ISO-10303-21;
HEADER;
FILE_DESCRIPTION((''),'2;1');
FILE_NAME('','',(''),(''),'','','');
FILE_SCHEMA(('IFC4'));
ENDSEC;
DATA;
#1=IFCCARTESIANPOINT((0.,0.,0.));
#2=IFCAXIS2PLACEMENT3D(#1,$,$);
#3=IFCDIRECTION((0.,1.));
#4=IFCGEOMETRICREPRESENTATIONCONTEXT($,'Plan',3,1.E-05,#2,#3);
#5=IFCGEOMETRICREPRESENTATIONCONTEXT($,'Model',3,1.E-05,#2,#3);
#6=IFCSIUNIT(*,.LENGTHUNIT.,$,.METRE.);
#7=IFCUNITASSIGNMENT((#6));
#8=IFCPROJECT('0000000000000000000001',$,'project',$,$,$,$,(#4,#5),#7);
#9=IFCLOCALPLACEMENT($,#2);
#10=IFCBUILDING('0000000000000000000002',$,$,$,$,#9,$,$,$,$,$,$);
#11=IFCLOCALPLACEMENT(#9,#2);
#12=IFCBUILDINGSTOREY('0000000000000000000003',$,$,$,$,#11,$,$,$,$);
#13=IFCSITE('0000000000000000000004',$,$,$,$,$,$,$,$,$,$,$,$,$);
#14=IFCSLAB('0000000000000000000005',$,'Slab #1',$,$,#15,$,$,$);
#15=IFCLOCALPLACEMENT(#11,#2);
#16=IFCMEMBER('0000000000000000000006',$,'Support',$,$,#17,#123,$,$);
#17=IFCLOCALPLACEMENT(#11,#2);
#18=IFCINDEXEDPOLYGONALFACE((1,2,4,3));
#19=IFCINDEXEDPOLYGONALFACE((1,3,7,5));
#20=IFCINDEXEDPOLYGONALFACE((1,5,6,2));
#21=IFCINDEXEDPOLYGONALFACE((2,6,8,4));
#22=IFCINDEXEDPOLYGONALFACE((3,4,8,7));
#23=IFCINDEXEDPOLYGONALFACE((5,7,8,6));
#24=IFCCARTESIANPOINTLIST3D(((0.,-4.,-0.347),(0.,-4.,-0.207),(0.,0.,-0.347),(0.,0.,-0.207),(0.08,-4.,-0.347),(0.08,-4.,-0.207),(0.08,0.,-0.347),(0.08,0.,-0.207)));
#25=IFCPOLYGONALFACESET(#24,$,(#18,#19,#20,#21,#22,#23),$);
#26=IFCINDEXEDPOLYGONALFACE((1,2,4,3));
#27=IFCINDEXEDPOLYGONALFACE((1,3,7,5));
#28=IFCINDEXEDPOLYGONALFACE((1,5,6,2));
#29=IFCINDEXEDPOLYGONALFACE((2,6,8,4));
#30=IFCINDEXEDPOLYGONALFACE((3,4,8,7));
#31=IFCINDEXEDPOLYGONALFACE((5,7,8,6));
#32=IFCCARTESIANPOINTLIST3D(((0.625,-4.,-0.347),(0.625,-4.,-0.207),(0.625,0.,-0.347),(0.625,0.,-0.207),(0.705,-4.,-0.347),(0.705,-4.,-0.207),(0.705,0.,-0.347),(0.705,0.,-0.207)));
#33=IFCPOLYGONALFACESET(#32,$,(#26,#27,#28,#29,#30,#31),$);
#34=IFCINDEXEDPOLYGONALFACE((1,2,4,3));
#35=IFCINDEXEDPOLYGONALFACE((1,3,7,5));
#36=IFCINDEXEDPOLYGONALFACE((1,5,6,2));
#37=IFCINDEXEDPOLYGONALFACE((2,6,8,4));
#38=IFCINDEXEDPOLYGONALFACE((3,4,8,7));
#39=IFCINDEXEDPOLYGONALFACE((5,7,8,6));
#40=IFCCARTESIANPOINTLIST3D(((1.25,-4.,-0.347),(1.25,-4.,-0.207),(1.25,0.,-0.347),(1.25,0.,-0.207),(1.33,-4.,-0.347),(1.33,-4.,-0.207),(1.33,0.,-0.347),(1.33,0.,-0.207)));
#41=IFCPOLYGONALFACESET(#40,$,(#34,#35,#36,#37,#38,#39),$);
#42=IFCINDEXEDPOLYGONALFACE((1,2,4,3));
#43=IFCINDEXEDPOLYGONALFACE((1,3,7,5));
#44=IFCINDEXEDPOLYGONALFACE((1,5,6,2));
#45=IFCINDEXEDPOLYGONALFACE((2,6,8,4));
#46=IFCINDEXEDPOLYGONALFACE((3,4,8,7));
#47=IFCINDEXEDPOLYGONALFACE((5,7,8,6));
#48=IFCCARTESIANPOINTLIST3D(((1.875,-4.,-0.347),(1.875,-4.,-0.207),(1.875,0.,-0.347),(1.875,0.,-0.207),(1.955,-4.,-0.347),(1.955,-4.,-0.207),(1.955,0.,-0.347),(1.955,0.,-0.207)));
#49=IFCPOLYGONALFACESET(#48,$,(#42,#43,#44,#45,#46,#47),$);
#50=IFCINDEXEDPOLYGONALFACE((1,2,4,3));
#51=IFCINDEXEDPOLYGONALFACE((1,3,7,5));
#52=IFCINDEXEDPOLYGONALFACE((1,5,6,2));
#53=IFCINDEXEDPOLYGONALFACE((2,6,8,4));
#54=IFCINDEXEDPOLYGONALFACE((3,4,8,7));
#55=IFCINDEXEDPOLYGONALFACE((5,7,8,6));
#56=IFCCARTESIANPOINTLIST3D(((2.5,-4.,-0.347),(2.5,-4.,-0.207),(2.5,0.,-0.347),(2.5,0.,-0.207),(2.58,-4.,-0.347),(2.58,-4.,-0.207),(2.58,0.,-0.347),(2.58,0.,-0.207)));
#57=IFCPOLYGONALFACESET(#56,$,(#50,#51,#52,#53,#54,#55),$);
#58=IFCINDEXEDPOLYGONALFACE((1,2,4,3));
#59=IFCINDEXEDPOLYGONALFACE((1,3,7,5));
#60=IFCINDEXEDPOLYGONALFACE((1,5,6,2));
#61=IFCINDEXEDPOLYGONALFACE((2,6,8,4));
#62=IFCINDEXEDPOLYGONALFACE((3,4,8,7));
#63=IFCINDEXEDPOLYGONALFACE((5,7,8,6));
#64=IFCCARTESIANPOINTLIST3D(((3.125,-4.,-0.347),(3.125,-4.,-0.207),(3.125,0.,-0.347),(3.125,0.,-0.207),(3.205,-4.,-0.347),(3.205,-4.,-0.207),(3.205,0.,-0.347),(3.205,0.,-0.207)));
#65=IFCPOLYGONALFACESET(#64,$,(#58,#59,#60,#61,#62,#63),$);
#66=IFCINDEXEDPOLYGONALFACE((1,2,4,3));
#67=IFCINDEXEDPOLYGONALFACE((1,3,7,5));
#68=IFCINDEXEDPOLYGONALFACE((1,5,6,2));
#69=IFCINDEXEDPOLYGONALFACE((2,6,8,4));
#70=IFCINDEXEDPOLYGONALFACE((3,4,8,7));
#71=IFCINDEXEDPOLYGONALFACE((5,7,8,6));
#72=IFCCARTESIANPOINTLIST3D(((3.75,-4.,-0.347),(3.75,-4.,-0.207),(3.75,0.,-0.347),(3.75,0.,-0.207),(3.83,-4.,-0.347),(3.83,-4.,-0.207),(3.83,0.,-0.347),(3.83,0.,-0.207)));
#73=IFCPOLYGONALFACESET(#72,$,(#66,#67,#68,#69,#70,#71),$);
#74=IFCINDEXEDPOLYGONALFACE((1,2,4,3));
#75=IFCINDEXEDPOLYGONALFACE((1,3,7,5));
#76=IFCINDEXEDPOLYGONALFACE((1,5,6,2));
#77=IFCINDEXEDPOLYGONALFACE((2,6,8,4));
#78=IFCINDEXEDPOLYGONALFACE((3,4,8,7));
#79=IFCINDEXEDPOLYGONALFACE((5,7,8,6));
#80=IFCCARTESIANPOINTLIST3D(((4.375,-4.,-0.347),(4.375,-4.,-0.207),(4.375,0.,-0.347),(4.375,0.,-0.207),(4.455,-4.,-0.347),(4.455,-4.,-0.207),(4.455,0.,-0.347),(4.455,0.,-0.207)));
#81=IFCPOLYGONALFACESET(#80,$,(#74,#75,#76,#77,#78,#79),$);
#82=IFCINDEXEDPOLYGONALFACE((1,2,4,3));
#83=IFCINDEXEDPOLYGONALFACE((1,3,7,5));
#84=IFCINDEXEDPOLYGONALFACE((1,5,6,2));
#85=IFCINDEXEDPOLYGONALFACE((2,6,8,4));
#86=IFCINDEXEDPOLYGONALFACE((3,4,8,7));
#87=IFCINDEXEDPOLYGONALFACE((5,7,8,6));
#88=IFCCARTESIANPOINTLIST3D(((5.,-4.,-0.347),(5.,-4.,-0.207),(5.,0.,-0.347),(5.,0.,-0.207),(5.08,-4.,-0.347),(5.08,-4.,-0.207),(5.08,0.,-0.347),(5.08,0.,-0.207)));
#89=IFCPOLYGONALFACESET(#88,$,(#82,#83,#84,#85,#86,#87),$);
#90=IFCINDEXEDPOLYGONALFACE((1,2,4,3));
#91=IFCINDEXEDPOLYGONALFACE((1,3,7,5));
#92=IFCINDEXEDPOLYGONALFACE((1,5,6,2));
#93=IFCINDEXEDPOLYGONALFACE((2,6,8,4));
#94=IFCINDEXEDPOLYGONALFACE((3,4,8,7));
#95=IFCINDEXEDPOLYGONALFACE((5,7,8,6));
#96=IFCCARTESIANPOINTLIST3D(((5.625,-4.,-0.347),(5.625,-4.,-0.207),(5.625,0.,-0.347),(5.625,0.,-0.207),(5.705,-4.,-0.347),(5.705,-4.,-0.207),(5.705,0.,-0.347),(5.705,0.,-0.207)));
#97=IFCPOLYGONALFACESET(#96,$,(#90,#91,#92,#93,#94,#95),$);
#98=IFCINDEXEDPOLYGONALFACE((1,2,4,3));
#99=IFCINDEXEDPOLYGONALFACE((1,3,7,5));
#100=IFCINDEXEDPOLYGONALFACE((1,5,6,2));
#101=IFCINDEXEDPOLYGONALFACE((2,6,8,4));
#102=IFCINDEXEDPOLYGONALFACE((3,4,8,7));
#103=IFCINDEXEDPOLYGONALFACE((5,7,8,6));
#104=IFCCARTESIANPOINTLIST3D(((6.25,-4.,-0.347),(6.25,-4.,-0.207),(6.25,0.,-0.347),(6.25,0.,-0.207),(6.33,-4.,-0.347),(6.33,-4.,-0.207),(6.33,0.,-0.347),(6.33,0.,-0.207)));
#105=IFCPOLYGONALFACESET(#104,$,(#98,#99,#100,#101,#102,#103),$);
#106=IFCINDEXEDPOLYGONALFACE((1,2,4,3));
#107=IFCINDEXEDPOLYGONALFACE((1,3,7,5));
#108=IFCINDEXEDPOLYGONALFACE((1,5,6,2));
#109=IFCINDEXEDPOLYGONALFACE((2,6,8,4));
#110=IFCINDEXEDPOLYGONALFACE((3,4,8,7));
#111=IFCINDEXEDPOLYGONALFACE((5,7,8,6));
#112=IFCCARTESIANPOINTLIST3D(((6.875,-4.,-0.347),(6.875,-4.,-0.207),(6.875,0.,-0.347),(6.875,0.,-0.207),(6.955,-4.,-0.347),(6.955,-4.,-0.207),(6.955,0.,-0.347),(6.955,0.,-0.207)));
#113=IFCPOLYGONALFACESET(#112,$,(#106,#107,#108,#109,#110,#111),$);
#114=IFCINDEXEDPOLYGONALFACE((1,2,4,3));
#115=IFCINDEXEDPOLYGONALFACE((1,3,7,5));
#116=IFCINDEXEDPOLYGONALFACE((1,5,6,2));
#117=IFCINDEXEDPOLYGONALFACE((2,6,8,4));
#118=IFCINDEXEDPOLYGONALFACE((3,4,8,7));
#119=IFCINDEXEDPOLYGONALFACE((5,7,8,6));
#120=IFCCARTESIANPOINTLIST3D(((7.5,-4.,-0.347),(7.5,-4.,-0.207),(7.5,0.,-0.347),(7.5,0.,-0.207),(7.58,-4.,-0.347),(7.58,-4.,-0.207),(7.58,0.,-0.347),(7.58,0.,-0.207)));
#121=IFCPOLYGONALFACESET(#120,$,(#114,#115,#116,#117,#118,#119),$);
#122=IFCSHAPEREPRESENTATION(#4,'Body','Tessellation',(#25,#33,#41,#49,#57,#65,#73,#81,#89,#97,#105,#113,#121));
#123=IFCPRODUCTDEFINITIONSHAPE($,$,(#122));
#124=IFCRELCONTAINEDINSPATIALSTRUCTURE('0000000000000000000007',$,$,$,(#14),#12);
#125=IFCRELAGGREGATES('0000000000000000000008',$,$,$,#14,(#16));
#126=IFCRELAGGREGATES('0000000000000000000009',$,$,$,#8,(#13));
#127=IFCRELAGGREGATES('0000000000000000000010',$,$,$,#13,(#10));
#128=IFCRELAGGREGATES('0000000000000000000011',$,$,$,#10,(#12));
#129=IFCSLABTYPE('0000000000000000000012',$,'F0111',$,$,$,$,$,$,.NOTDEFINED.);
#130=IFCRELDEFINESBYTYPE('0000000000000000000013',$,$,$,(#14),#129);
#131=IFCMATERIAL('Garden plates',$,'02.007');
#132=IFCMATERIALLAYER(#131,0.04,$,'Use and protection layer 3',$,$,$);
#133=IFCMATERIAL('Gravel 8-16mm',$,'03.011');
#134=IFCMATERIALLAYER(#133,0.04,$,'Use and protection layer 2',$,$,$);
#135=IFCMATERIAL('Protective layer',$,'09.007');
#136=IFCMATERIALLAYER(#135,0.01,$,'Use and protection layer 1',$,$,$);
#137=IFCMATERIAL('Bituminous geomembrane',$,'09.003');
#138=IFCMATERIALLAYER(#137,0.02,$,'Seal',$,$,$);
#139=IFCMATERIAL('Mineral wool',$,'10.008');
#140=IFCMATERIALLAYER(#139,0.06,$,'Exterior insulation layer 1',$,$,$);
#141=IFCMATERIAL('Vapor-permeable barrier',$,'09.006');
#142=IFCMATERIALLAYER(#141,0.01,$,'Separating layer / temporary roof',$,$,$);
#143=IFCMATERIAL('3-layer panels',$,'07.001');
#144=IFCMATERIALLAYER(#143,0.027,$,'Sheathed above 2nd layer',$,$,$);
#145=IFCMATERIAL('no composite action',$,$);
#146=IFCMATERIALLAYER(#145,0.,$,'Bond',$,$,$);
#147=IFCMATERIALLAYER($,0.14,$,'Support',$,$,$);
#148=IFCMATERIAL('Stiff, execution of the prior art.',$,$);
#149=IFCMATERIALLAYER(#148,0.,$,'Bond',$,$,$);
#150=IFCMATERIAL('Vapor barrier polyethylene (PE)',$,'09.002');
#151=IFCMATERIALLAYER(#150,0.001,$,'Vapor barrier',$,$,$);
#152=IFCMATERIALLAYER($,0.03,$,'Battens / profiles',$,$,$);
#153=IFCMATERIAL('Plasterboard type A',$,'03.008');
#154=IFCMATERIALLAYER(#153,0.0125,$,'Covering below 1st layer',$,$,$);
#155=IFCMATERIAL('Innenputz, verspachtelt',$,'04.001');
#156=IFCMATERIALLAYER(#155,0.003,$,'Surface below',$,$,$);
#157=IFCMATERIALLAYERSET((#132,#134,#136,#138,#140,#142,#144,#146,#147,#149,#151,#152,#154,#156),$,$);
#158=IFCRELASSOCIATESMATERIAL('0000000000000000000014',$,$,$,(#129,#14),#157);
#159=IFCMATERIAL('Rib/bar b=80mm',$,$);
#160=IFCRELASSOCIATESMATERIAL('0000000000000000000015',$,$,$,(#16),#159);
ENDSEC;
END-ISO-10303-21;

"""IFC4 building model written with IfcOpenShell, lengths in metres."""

from ifc_helpers import new_model, si_unit, direction, frame, frame_2d, origin, place, context, project, spatial, rectangle, extrude, material, layer, layer_set, type_object, element, aggregate, save


model = new_model("IFC4")

# Units and contexts
plan_context = context("Plan", 3, precision=1e-05, world=origin(), true_north=direction((0.0, 1.0)))
model_context = context("Model", 3, precision=1e-05, world=origin(), true_north=direction((0.0, 1.0)))
ifc_project = project(units=[si_unit("LENGTHUNIT", "METRE")], contexts=[plan_context, model_context])

# Site, building, storey
site = spatial("IfcSite", under=ifc_project)
building_placement = place(None, origin())
building = spatial("IfcBuilding", under=site, at=building_placement)
storey_placement = place(building_placement, origin())
storey = spatial("IfcBuildingStorey", under=building, at=storey_placement)

# Slab, member
ifc_material_1 = material(Name="Garden plates", Category="02.007")
ifc_layer_1 = layer(ifc_material_1, 0.04, Name="Use and protection layer 3")
ifc_material_2 = material(Name="Gravel 8-16mm", Category="03.011")
ifc_layer_2 = layer(ifc_material_2, 0.04, Name="Use and protection layer 2")
ifc_material_3 = material(Name="Protective layer", Category="09.007")
ifc_layer_3 = layer(ifc_material_3, 0.01, Name="Use and protection layer 1")
ifc_material_4 = material(Name="Bituminous geomembrane", Category="09.003")
ifc_layer_4 = layer(ifc_material_4, 0.02, Name="Seal")
ifc_material_5 = material(Name="Mineral wool", Category="10.008")
ifc_layer_5 = layer(ifc_material_5, 0.06, Name="Exterior insulation layer 1")
ifc_material_6 = material(Name="Vapor-permeable barrier", Category="09.006")
ifc_layer_6 = layer(ifc_material_6, 0.01, Name="Separating layer / temporary roof")
ifc_material_7 = material(Name="3-layer panels", Category="07.001")
ifc_layer_7 = layer(ifc_material_7, 0.027, Name="Sheathed above 2nd layer")
ifc_material_8 = material(Name="no composite action")
ifc_layer_8 = layer(ifc_material_8, 0.0, Name="Bond")
ifc_layer_9 = layer(None, 0.14, Name="Support")
ifc_material_9 = material(Name="Stiff, execution of the prior art.")
ifc_layer_10 = layer(ifc_material_9, 0.0, Name="Bond")
ifc_material_10 = material(Name="Vapor barrier polyethylene (PE)", Category="09.002")
ifc_layer_11 = layer(ifc_material_10, 0.001, Name="Vapor barrier")
ifc_layer_12 = layer(None, 0.03, Name="Battens / profiles")
ifc_material_11 = material(Name="Plasterboard type A", Category="03.008")
ifc_layer_13 = layer(ifc_material_11, 0.0125, Name="Covering below 1st layer")
ifc_material_12 = material(Name="Innenputz, verspachtelt", Category="04.001")
ifc_layer_14 = layer(ifc_material_12, 0.003, Name="Surface below")
ifc_layer_set = layer_set([ifc_layer_1, ifc_layer_2, ifc_layer_3, ifc_layer_4, ifc_layer_5, ifc_layer_6, ifc_layer_7, ifc_layer_8, ifc_layer_9, ifc_layer_10, ifc_layer_11, ifc_layer_12, ifc_layer_13, ifc_layer_14])
slab_type = type_object("IfcSlabType", Name="F0111", PredefinedType="NOTDEFINED", material=ifc_layer_set)
slab_placement = place(None, frame((0.0, 0.0, 0.0), z_axis=(0.0, 0.0, -1.0), x_axis=(1.0, 0.0, 0.0)))
slab = element("IfcSlab", 1, at=slab_placement, inside=storey, type_object=slab_type, material=ifc_layer_set, Name="Slab #1")
ifc_material_13 = material(Name="Rib/bar b=80mm")
member_1_placement = place(slab_placement, origin())
member_1 = element("IfcMember", 2, at=member_1_placement, material=ifc_material_13, Name="Support", context=plan_context, shape_type="SweptSolid", body=[
    extrude(rectangle(XDim=0.08, YDim=0.14, at=frame_2d((0.04, 0.07), x_axis=(1.0, 0.0))), frame((0.0, 4.0, 0.207), z_axis=(0.0, -1.0, 0.0), x_axis=(1.0, 0.0, 0.0)), (0.0, 0.0, 1.0), 4.0),
    extrude(rectangle(XDim=0.08, YDim=0.14, at=frame_2d((0.04, 0.07), x_axis=(1.0, 0.0))), frame((0.625, 4.0, 0.207), z_axis=(0.0, -1.0, 0.0), x_axis=(1.0, 0.0, 0.0)), (0.0, 0.0, 1.0), 4.0),
    extrude(rectangle(XDim=0.08, YDim=0.14, at=frame_2d((0.04, 0.07), x_axis=(1.0, 0.0))), frame((1.25, 4.0, 0.207), z_axis=(0.0, -1.0, 0.0), x_axis=(1.0, 0.0, 0.0)), (0.0, 0.0, 1.0), 4.0),
    extrude(rectangle(XDim=0.08, YDim=0.14, at=frame_2d((0.04, 0.07), x_axis=(1.0, 0.0))), frame((1.875, 4.0, 0.207), z_axis=(0.0, -1.0, 0.0), x_axis=(1.0, 0.0, 0.0)), (0.0, 0.0, 1.0), 4.0),
    extrude(rectangle(XDim=0.08, YDim=0.14, at=frame_2d((0.04, 0.07), x_axis=(1.0, 0.0))), frame((2.5, 4.0, 0.207), z_axis=(0.0, -1.0, 0.0), x_axis=(1.0, 0.0, 0.0)), (0.0, 0.0, 1.0), 4.0),
    extrude(rectangle(XDim=0.08, YDim=0.14, at=frame_2d((0.04, 0.07), x_axis=(1.0, 0.0))), frame((3.125, 4.0, 0.207), z_axis=(0.0, -1.0, 0.0), x_axis=(1.0, 0.0, 0.0)), (0.0, 0.0, 1.0), 4.0),
    extrude(rectangle(XDim=0.08, YDim=0.14, at=frame_2d((0.04, 0.07), x_axis=(1.0, 0.0))), frame((3.75, 4.0, 0.207), z_axis=(0.0, -1.0, 0.0), x_axis=(1.0, 0.0, 0.0)), (0.0, 0.0, 1.0), 4.0),
    extrude(rectangle(XDim=0.08, YDim=0.14, at=frame_2d((0.04, 0.07), x_axis=(1.0, 0.0))), frame((4.375, 4.0, 0.207), z_axis=(0.0, -1.0, 0.0), x_axis=(1.0, 0.0, 0.0)), (0.0, 0.0, 1.0), 4.0),
    extrude(rectangle(XDim=0.08, YDim=0.14, at=frame_2d((0.04, 0.07), x_axis=(1.0, 0.0))), frame((5.0, 4.0, 0.207), z_axis=(0.0, -1.0, 0.0), x_axis=(1.0, 0.0, 0.0)), (0.0, 0.0, 1.0), 4.0),
    extrude(rectangle(XDim=0.08, YDim=0.14, at=frame_2d((0.04, 0.07), x_axis=(1.0, 0.0))), frame((5.625, 4.0, 0.207), z_axis=(0.0, -1.0, 0.0), x_axis=(1.0, 0.0, 0.0)), (0.0, 0.0, 1.0), 4.0),
    extrude(rectangle(XDim=0.08, YDim=0.14, at=frame_2d((0.04, 0.07), x_axis=(1.0, 0.0))), frame((6.25, 4.0, 0.207), z_axis=(0.0, -1.0, 0.0), x_axis=(1.0, 0.0, 0.0)), (0.0, 0.0, 1.0), 4.0),
    extrude(rectangle(XDim=0.08, YDim=0.14, at=frame_2d((0.04, 0.07), x_axis=(1.0, 0.0))), frame((6.875, 4.0, 0.207), z_axis=(0.0, -1.0, 0.0), x_axis=(1.0, 0.0, 0.0)), (0.0, 0.0, 1.0), 4.0),
    extrude(rectangle(XDim=0.08, YDim=0.14, at=frame_2d((0.04, 0.07), x_axis=(1.0, 0.0))), frame((7.5, 4.0, 0.207), z_axis=(0.0, -1.0, 0.0), x_axis=(1.0, 0.0, 0.0)), (0.0, 0.0, 1.0), 4.0),
])
aggregate(slab, [member_1])

save(model, "model.ifc")
